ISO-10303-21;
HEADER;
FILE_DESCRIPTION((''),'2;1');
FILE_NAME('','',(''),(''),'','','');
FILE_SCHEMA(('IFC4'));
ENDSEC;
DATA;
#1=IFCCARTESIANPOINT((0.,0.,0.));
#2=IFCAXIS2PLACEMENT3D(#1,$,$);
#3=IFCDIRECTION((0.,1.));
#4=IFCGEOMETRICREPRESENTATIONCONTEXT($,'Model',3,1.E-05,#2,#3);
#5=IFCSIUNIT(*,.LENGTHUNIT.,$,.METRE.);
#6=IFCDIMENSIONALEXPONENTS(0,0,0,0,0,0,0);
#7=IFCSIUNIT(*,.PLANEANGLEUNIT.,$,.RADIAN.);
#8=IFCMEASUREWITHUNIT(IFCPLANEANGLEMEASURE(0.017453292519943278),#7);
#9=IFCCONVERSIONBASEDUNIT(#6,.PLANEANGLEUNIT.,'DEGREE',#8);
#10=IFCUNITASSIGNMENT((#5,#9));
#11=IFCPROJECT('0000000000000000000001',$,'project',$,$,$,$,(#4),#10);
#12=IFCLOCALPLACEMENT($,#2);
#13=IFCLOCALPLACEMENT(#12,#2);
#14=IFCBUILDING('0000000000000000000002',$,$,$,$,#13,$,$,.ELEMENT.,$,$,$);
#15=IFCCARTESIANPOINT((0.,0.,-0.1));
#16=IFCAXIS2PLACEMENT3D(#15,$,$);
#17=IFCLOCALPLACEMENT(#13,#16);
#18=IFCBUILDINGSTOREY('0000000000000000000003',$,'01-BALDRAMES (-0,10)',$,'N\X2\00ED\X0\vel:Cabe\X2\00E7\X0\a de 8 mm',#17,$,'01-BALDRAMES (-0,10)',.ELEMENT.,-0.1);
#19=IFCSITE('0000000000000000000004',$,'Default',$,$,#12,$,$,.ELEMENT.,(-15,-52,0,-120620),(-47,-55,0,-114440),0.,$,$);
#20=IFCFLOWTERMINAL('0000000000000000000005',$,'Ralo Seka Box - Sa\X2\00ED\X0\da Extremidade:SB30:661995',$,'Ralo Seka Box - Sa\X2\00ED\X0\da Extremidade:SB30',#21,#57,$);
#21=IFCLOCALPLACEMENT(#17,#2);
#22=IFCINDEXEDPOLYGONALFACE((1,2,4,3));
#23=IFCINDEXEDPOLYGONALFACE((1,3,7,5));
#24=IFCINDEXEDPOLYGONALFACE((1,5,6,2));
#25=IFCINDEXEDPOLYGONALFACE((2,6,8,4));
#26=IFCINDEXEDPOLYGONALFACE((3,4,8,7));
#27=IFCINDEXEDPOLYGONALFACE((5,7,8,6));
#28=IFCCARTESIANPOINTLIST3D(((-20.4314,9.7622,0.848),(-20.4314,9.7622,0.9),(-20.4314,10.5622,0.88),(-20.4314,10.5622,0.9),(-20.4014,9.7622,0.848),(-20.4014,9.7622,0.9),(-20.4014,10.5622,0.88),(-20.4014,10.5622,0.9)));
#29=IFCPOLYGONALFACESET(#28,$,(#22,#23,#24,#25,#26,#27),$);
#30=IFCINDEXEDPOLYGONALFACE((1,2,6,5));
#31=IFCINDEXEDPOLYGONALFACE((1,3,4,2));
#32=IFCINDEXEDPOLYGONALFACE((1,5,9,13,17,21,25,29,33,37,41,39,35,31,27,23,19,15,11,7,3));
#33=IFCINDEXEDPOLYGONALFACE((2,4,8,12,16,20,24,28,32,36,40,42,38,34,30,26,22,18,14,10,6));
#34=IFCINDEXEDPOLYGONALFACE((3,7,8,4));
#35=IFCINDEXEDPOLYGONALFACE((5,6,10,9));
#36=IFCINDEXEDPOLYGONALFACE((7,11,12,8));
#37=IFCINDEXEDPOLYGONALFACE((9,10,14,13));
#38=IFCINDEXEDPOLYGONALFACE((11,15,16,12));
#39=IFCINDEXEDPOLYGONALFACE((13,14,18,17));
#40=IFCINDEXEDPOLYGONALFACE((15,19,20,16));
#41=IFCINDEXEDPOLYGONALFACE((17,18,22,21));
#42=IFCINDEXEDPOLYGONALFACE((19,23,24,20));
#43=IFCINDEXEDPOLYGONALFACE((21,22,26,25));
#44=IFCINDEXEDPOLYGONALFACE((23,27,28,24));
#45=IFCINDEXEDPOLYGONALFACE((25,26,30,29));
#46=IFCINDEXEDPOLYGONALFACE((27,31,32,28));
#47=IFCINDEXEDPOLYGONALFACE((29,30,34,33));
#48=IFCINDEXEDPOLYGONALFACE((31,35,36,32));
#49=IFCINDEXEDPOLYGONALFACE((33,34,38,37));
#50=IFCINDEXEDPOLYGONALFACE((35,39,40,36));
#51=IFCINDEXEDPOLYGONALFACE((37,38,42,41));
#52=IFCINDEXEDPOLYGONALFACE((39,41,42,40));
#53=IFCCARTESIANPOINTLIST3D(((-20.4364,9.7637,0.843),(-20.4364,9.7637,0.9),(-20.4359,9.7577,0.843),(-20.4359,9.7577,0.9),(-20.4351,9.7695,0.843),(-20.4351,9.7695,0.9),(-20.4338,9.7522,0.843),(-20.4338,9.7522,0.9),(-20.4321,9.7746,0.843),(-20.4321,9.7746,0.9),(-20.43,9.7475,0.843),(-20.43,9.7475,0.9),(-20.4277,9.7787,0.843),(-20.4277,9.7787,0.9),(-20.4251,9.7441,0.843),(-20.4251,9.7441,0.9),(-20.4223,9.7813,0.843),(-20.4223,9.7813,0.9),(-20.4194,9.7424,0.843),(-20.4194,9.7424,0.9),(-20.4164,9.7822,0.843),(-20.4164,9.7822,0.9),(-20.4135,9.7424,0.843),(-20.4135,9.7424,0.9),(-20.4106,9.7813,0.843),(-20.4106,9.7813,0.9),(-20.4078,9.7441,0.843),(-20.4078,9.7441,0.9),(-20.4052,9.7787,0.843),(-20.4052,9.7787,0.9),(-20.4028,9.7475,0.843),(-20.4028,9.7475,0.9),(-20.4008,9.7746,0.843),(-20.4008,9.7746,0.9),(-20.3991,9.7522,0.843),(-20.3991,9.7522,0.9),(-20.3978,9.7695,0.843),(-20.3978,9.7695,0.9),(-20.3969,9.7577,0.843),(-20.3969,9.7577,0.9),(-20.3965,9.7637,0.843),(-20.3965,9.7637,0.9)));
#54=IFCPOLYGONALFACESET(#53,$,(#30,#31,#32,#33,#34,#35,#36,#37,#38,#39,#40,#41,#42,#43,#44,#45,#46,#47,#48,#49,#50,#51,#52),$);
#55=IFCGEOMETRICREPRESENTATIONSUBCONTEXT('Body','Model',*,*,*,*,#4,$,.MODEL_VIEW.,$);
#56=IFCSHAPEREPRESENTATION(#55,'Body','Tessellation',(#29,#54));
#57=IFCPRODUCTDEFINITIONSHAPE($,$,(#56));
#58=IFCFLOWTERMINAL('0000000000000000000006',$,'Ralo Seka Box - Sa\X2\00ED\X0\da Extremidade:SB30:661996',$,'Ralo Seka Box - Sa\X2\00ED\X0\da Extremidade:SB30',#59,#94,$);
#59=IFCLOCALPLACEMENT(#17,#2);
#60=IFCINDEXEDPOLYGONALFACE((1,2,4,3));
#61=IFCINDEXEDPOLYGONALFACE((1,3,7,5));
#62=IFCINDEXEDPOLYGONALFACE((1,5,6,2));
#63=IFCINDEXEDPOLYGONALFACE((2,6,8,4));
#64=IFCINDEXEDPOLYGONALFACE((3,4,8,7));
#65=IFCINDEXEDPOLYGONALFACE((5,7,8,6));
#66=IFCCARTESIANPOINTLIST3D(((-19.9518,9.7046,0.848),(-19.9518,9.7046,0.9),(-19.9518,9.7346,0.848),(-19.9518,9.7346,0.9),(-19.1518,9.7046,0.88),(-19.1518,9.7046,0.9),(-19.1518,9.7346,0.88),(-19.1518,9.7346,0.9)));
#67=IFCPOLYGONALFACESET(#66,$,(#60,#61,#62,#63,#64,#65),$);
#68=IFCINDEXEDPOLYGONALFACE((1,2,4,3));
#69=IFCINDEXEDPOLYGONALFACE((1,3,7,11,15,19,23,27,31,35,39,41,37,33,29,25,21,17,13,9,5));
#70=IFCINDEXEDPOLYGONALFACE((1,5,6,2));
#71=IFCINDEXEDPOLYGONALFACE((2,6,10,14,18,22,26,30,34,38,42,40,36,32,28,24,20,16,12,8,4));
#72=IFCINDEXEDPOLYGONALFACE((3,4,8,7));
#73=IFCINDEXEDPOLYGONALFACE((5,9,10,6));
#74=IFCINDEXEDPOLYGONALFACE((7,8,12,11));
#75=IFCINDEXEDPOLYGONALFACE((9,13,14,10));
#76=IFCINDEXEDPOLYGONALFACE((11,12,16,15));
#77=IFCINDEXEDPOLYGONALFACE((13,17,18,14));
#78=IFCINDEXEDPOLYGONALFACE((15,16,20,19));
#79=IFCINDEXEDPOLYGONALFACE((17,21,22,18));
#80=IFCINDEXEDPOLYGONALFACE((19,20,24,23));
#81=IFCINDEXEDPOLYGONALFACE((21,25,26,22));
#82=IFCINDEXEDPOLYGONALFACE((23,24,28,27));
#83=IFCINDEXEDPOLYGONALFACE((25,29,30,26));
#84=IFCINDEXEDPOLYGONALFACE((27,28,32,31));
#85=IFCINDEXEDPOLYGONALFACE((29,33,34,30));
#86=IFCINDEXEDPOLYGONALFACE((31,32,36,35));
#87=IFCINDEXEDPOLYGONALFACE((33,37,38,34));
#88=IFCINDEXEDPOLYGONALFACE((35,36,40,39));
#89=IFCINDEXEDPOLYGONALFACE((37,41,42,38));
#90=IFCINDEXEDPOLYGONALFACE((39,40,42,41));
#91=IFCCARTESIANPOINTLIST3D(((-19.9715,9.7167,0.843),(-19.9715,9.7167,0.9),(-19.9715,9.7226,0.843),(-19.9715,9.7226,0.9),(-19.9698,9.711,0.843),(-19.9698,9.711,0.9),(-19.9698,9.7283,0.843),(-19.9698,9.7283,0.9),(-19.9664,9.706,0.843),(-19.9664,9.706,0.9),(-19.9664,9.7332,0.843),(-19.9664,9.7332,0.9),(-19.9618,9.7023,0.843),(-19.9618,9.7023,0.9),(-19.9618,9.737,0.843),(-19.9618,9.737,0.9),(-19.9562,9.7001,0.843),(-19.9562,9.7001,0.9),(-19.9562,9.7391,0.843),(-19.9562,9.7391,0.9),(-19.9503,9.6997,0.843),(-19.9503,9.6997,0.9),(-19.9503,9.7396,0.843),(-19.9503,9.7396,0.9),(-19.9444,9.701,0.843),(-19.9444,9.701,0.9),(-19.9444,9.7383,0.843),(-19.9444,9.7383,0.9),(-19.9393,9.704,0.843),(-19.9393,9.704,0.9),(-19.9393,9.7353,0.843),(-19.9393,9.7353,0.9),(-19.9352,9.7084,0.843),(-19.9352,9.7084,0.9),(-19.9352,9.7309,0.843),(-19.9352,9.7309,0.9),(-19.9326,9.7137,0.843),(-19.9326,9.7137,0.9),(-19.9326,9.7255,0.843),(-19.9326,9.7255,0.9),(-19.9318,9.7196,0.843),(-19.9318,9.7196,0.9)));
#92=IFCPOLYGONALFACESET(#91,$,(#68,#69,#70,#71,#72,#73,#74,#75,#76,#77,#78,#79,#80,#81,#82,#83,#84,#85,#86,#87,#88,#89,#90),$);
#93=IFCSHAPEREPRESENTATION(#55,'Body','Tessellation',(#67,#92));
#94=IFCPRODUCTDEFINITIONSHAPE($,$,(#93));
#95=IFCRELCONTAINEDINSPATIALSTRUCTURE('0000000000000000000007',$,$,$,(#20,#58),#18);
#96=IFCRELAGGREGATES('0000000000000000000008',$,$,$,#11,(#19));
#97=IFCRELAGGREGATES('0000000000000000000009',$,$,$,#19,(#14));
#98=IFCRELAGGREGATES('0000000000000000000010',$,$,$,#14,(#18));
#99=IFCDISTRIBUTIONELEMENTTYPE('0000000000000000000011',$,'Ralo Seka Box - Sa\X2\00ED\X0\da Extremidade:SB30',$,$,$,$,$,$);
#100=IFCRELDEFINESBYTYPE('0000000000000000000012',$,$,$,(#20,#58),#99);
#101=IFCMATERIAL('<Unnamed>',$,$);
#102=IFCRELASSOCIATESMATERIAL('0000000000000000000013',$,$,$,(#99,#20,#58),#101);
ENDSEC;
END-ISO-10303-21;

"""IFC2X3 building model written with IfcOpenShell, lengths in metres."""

from ifc_helpers import new_model, entity, si_unit, converted_unit, direction, frame, frame_2d, origin, place, context, subcontext, project, spatial, polyline, circle, outline, extrude, source, transform, mapped, material, type_object, type_shapes, element, save


model = new_model("IFC2X3")

# Units and contexts
model_context = context("Model", 3, precision=1e-05, world=origin(), true_north=direction((0.0, 1.0)))
body_context = subcontext(model_context, "Body", "Model", "MODEL_VIEW")
ifc_project = project(units=[si_unit("LENGTHUNIT", "METRE"), converted_unit("PLANEANGLEUNIT", "DEGREE", entity("IfcPlaneAngleMeasure", 0.017453292519943278), si_unit("PLANEANGLEUNIT", "RADIAN"), dimensions=[0, 0, 0, 0, 0, 0, 0])], contexts=[model_context])

# Site, building, storey
site_placement = place(None, origin())
site = spatial("IfcSite", under=ifc_project, at=site_placement, Name="Default", CompositionType="ELEMENT", RefLatitude=(-15, -52, 0, -120620), RefLongitude=(-47, -55, 0, -114440), RefElevation=0.0)
building_placement = place(site_placement, origin())
building = spatial("IfcBuilding", under=site, at=building_placement, CompositionType="ELEMENT")
storey_placement = place(building_placement, frame((0.0, 0.0, -0.1)))
storey = spatial("IfcBuildingStorey", under=building, at=storey_placement, Name="01-BALDRAMES (-0,10)", ObjectType="Nível:Cabeça de 8 mm", LongName="01-BALDRAMES (-0,10)", CompositionType="ELEMENT", Elevation=-0.1)

# Shared definitions
ifc_material = material(Name="<Unnamed>")

# Flow terminals
distribution_element_type_1 = type_object("IfcDistributionElementType", Name="Ralo Seka Box - Saída Extremidade:SB30", material=ifc_material)
shared_shape_1 = source(origin(), body_context, "Body", "SweptSolid", [
    extrude(outline(polyline([(-0.3996, -0.018), (0.401, -0.018), (0.399, 0.034), (-0.4004, 0.002), (-0.3996, -0.018)])), frame((0.4, -0.015, -0.018), z_axis=(0.0, 1.0, 0.0), x_axis=(-0.999201, 0.0, -0.039968)), (0.0, 0.0, 1.0), 0.03),
    extrude(circle(Radius=0.02, at=frame_2d((0.0, 0.0), x_axis=(1.0, 0.0))), frame((0.0, 0.0, -0.057)), (0.0, 0.0, 1.0), 0.057),
])
type_shapes(distribution_element_type_1, [shared_shape_1])
for number, where, z_axis, x_axis, name in (
    (1, (-20.4164, 9.7622, 0.9), (0.0, 0.0, 1.0), (-0.000001, 1.0, 0.0), "Ralo Seka Box - Saída Extremidade:SB30:661995"),
):
    element("IfcFlowTerminal", number, at=place(storey_placement, frame(where, z_axis=z_axis, x_axis=x_axis)), inside=storey, type_object=distribution_element_type_1, material=ifc_material, Name=name, ObjectType="Ralo Seka Box - Saída Extremidade:SB30", context=body_context, shape_type="MappedRepresentation", body=[
        mapped(shared_shape_1, transform((0.0, 0.0, 0.0), scale=1.0)),
    ])
flow_terminal_1_placement = place(storey_placement, frame((-19.9518, 9.7196, 0.9)))
element("IfcFlowTerminal", 2, at=flow_terminal_1_placement, inside=storey, type_object=distribution_element_type_1, material=ifc_material, Name="Ralo Seka Box - Saída Extremidade:SB30:661996", ObjectType="Ralo Seka Box - Saída Extremidade:SB30", context=body_context, shape_type="MappedRepresentation", body=[
    mapped(shared_shape_1, transform((0.0, 0.0, 0.0), scale=1.0)),
])

save(model, "model.ifc")
